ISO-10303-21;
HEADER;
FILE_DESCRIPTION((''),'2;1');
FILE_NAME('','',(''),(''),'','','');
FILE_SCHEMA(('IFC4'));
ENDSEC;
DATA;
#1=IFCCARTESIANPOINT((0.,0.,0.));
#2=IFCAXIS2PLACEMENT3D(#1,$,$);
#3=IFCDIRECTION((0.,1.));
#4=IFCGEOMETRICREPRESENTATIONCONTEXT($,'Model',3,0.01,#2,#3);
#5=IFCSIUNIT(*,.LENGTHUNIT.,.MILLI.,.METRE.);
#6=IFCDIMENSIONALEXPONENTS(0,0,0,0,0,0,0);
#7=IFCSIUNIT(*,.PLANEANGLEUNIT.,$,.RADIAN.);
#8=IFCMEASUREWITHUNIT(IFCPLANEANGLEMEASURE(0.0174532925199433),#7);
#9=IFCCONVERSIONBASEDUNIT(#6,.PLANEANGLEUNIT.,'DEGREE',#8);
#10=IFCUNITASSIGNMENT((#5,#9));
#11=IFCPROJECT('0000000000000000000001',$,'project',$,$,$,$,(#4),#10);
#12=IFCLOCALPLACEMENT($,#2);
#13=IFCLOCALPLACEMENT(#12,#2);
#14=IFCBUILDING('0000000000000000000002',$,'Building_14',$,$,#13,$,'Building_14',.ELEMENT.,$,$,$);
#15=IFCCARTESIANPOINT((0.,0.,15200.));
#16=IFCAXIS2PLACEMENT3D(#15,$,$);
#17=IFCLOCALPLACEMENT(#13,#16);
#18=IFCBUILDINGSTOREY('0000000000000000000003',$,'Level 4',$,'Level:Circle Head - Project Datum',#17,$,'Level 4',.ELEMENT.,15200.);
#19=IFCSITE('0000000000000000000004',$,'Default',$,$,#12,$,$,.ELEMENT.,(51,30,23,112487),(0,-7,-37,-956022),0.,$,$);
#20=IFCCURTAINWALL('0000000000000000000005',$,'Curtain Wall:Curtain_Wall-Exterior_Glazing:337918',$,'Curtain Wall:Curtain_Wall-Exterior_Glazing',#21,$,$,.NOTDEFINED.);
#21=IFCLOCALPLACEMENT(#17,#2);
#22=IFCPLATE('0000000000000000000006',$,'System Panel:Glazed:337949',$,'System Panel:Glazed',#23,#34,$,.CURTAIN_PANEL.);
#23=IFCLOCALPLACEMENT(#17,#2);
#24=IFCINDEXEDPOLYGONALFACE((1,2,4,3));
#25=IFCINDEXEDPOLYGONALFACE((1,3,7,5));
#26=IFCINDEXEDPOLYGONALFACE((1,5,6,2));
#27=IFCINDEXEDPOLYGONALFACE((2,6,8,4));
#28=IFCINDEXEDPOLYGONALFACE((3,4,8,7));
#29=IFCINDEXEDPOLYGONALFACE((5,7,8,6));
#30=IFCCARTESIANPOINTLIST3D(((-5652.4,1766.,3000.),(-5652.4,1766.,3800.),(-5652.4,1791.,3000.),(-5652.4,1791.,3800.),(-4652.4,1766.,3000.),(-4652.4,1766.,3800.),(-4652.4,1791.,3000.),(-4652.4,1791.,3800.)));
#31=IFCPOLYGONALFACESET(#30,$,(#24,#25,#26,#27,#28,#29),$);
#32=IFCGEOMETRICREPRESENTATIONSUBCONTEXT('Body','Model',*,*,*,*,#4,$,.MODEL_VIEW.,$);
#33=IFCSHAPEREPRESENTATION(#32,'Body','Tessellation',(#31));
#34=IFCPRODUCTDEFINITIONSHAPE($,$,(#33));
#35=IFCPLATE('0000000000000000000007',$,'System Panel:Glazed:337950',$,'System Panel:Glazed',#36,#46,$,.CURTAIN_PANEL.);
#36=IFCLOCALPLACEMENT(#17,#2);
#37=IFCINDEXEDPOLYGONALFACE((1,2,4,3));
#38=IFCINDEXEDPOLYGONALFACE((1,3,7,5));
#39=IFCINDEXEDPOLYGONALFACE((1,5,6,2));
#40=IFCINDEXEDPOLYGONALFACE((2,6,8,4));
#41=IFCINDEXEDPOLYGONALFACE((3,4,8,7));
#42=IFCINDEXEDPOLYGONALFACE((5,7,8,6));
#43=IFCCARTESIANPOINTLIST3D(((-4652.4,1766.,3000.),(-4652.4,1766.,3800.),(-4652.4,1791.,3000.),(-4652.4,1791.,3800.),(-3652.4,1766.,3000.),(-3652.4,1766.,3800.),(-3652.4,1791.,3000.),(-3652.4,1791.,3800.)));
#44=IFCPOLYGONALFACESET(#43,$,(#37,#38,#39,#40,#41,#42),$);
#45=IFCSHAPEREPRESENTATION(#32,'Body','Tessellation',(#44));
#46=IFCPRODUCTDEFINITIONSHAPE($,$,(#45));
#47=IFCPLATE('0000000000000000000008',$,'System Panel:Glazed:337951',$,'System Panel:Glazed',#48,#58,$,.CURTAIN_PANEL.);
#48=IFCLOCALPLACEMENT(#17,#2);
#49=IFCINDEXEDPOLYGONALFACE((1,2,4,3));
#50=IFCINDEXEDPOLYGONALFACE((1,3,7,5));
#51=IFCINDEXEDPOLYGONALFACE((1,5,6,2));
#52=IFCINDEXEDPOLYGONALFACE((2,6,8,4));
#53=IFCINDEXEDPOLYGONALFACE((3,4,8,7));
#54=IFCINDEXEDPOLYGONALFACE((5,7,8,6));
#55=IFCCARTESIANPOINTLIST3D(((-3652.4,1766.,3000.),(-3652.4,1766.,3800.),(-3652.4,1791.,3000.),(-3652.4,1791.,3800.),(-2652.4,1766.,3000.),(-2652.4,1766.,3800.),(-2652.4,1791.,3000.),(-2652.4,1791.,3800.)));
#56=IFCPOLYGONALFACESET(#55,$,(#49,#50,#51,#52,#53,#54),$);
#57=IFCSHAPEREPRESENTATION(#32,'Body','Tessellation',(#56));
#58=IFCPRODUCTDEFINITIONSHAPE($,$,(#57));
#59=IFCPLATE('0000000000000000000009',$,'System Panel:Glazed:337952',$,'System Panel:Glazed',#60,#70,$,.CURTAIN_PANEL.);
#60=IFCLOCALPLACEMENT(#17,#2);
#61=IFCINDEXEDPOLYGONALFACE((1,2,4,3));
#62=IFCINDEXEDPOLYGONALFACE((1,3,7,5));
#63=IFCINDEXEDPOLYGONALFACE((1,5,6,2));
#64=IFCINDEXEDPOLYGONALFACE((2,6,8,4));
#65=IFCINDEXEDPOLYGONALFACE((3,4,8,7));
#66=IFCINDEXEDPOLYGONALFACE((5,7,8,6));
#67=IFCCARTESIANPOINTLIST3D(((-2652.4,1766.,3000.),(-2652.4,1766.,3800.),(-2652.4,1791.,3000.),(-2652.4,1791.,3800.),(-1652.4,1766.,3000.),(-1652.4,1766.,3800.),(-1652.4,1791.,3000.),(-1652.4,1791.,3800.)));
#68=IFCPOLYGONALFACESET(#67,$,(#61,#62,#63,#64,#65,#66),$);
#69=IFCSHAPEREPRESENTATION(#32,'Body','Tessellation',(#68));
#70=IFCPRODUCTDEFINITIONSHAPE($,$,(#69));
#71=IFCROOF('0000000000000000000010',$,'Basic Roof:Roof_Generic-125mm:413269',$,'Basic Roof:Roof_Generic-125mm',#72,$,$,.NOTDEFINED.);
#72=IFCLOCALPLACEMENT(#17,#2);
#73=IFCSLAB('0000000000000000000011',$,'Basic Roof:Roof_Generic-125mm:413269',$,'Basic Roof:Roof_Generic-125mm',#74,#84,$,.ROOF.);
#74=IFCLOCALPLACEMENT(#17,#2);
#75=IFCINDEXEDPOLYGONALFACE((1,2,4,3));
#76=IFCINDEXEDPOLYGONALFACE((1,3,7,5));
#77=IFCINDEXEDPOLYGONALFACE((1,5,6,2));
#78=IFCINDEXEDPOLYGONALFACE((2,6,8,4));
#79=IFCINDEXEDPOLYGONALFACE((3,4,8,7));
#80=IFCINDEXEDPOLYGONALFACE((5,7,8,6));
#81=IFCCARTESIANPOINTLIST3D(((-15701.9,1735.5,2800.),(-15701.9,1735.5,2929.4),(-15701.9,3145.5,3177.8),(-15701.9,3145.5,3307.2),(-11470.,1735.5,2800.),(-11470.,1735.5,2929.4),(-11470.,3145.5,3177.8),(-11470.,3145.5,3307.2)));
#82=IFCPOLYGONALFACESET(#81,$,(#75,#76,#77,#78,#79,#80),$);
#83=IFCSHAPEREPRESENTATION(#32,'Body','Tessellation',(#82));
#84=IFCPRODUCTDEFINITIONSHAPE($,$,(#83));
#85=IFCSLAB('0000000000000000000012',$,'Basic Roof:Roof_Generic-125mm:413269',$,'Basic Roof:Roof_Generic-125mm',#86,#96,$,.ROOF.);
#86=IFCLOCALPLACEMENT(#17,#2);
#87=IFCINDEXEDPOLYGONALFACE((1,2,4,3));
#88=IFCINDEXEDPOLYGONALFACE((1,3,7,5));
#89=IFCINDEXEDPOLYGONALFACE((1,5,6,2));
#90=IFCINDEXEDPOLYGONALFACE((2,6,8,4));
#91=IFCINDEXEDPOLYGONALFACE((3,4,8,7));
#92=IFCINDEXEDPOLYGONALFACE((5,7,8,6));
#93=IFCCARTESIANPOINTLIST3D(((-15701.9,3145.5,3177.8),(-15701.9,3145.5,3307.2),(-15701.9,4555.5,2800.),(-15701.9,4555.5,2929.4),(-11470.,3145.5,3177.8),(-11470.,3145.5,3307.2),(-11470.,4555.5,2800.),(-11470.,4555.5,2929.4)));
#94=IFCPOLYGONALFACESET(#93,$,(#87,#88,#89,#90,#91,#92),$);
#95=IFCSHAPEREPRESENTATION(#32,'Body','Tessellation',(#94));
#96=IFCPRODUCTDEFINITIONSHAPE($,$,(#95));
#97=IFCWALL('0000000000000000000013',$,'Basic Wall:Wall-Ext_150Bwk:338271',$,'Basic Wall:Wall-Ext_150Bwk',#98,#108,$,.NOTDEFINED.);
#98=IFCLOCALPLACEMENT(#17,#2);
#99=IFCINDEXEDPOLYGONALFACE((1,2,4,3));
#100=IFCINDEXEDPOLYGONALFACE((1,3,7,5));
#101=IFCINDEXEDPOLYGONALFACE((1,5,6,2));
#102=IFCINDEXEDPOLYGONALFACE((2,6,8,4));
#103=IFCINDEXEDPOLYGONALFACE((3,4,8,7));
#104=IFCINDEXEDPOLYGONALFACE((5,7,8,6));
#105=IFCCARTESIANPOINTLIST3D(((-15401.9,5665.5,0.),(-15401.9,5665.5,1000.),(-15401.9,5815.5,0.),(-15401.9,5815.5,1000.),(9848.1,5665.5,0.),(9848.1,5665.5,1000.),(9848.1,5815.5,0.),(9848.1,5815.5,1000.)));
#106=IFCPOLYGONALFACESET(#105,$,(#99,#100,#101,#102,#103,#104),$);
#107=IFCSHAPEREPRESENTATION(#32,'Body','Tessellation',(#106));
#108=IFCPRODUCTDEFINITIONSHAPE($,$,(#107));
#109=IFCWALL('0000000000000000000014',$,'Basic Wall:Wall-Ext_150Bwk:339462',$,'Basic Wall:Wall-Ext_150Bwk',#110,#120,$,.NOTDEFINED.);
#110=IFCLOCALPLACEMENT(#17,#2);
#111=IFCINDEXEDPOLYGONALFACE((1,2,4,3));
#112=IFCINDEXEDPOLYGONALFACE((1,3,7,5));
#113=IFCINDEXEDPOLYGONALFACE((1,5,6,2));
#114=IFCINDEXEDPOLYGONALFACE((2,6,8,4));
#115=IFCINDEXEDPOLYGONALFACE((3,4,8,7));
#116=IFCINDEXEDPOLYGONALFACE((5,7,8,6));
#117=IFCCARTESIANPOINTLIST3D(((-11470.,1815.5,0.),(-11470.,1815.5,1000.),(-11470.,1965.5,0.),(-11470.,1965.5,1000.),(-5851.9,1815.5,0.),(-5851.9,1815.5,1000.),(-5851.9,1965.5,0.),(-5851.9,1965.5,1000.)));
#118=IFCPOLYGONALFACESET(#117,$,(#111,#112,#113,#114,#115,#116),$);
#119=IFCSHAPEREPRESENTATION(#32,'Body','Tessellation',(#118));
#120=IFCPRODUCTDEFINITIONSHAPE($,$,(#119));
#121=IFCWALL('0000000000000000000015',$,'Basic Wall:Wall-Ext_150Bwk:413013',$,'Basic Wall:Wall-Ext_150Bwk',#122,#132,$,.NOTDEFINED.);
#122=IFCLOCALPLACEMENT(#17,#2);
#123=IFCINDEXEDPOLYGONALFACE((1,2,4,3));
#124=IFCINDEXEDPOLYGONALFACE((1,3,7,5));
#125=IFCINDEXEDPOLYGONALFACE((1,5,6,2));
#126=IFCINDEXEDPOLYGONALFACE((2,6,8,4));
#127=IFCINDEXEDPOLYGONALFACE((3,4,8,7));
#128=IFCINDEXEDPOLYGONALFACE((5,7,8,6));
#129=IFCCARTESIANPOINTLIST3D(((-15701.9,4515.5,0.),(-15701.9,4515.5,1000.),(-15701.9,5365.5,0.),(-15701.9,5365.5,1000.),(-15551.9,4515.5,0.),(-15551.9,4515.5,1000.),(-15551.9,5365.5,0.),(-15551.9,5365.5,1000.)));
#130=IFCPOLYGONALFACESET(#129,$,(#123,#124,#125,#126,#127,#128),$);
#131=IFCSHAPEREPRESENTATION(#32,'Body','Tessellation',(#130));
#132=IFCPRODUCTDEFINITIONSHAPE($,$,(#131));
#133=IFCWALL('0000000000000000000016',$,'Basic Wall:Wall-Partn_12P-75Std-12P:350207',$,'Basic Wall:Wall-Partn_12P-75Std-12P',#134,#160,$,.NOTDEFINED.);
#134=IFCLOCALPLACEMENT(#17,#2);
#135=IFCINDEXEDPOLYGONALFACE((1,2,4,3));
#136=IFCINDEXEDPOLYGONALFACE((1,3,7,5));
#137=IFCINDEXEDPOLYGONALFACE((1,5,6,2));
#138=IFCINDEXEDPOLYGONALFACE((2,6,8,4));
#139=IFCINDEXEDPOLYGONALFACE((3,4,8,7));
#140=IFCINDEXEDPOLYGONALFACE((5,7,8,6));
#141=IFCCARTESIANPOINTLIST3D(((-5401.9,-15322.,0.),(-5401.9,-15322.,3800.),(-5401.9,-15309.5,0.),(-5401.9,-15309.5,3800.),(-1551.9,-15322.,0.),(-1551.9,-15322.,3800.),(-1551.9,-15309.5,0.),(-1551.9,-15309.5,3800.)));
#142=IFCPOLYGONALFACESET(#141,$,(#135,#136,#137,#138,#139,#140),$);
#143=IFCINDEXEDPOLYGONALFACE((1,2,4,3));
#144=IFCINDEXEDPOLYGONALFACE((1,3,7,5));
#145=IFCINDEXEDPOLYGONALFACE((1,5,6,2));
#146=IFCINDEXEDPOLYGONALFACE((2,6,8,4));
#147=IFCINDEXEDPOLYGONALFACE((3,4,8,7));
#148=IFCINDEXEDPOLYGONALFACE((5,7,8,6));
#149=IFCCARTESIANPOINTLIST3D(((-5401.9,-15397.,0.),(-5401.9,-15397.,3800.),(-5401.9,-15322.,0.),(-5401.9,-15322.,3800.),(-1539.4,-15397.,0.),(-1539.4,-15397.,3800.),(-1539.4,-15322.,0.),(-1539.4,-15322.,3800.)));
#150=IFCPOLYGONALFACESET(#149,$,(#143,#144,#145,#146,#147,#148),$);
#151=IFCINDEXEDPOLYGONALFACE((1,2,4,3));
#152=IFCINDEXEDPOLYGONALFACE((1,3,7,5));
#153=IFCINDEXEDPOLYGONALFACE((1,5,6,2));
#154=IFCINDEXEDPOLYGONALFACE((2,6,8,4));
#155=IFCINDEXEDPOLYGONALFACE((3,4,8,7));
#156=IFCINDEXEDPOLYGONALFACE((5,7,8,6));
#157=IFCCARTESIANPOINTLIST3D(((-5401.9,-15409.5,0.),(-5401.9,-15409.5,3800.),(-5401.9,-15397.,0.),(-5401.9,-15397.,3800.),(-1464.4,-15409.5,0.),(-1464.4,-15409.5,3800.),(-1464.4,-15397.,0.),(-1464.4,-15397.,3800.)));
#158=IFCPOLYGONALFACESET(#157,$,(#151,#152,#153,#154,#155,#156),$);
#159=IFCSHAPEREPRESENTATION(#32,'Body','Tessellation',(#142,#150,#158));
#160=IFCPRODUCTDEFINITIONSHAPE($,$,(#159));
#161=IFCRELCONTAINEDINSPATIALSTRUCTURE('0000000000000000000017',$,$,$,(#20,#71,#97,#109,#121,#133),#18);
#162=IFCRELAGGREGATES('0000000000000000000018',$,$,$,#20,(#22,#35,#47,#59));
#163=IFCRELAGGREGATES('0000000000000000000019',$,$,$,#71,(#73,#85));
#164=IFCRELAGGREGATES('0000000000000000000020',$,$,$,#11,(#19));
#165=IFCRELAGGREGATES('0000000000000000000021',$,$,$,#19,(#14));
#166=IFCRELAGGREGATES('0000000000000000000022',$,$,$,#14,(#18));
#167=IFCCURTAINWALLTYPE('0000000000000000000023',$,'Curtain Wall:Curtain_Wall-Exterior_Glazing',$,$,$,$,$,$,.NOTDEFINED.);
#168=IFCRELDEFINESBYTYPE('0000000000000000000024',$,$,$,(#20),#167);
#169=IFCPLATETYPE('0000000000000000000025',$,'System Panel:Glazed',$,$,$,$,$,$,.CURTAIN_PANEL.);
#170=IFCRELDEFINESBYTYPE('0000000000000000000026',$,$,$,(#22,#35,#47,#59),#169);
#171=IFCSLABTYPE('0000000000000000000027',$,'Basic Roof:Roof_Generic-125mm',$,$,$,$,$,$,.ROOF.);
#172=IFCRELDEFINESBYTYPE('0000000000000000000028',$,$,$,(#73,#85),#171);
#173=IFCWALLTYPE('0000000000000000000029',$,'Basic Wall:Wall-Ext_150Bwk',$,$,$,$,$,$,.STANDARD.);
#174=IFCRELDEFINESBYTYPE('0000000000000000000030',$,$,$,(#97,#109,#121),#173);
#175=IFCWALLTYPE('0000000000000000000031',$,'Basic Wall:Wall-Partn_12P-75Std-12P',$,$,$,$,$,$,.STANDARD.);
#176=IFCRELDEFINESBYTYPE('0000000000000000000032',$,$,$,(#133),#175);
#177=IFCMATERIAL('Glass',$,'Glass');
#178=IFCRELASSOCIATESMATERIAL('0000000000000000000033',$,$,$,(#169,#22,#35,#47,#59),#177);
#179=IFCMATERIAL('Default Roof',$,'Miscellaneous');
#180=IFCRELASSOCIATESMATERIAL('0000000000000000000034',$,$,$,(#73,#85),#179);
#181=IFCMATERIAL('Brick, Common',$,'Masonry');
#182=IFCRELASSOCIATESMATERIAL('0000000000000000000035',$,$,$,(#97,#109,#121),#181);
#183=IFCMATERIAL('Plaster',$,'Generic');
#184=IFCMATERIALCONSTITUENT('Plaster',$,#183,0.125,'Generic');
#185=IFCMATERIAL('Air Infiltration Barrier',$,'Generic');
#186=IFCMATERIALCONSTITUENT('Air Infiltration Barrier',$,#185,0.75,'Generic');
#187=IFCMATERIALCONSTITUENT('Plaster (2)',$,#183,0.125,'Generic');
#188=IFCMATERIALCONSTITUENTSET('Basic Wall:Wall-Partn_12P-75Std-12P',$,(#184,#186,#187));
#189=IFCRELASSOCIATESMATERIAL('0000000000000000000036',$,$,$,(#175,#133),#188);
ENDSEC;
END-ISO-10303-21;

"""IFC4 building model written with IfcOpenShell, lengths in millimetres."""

from ifc_helpers import new_model, entity, si_unit, converted_unit, direction, frame, origin, place, context, subcontext, project, spatial, indexed_curve, outline, extrude, source, transform, mapped, material, constituent, constituent_set, type_object, type_shapes, element, aggregate, save


model = new_model("IFC4")

# Units and contexts
model_context = context("Model", 3, precision=0.01, world=origin(), true_north=direction((0.0, 1.0)))
body_context = subcontext(model_context, "Body", "Model", "MODEL_VIEW")
ifc_project = project(units=[si_unit("LENGTHUNIT", "METRE", prefix="MILLI"), converted_unit("PLANEANGLEUNIT", "DEGREE", entity("IfcPlaneAngleMeasure", 0.0174532925199433), si_unit("PLANEANGLEUNIT", "RADIAN"), dimensions=[0, 0, 0, 0, 0, 0, 0])], contexts=[model_context])

# Site, building, storey
site_placement = place(None, origin())
site = spatial("IfcSite", under=ifc_project, at=site_placement, Name="Default", CompositionType="ELEMENT", RefLatitude=(51, 30, 23, 112487), RefLongitude=(0, -7, -37, -956022), RefElevation=0.0)
building_placement = place(site_placement, origin())
building = spatial("IfcBuilding", under=site, at=building_placement, Name="Building_14", LongName="Building_14", CompositionType="ELEMENT")
storey_placement = place(building_placement, frame((0.0, 0.0, 15200.0)))
storey = spatial("IfcBuildingStorey", under=building, at=storey_placement, Name="Level 4", ObjectType="Level:Circle Head - Project Datum", LongName="Level 4", CompositionType="ELEMENT", Elevation=15200.0)

# Curtain wall, plates
curtain_wall_type = type_object("IfcCurtainWallType", Name="Curtain Wall:Curtain_Wall-Exterior_Glazing", PredefinedType="NOTDEFINED")
curtain_wall_placement = place(storey_placement, frame((0.0, 0.0, -15200.0)))
curtain_wall = element("IfcCurtainWall", 1, at=curtain_wall_placement, inside=storey, type_object=curtain_wall_type, Name="Curtain Wall:Curtain_Wall-Exterior_Glazing:337918", ObjectType="Curtain Wall:Curtain_Wall-Exterior_Glazing", PredefinedType="NOTDEFINED")
ifc_material_1 = material(Name="Glass", Category="Glass")
plate_type_1 = type_object("IfcPlateType", Name="System Panel:Glazed", PredefinedType="CURTAIN_PANEL", material=ifc_material_1)
shared_shape_1 = source(origin(), body_context, "Body", "SweptSolid", [
    extrude(outline(indexed_curve([(-12.5, -500.0), (12.5, -500.0), (12.5, 500.0), (-12.5, 500.0), (-12.5, -500.0)], self_intersect=False)), frame((0.0, -37.0, 0.0), z_axis=(0.0, 0.0, 1.0), x_axis=(0.0, 1.0, 0.0)), (0.0, 0.0, 1.0), 800.0),
])
type_shapes(plate_type_1, [shared_shape_1])
plate_1_placement = place(curtain_wall_placement, frame((-5152.4, 1815.5, 18200.0)))
plate_1 = element("IfcPlate", 2, at=plate_1_placement, type_object=plate_type_1, material=ifc_material_1, Name="System Panel:Glazed:337949", ObjectType="System Panel:Glazed", PredefinedType="CURTAIN_PANEL", context=body_context, shape_type="MappedRepresentation", body=[
    mapped(shared_shape_1, transform((0.0, 0.0, 0.0), scale=1.0)),
])
plate_2_placement = place(curtain_wall_placement, frame((-4152.4, 1815.5, 18200.0)))
plate_2 = element("IfcPlate", 3, at=plate_2_placement, type_object=plate_type_1, material=ifc_material_1, Name="System Panel:Glazed:337950", ObjectType="System Panel:Glazed", PredefinedType="CURTAIN_PANEL", context=body_context, shape_type="MappedRepresentation", body=[
    mapped(shared_shape_1, transform((0.0, 0.0, 0.0), scale=1.0)),
])
plate_3_placement = place(curtain_wall_placement, frame((-3152.4, 1815.5, 18200.0)))
plate_3 = element("IfcPlate", 4, at=plate_3_placement, type_object=plate_type_1, material=ifc_material_1, Name="System Panel:Glazed:337951", ObjectType="System Panel:Glazed", PredefinedType="CURTAIN_PANEL", context=body_context, shape_type="MappedRepresentation", body=[
    mapped(shared_shape_1, transform((0.0, 0.0, 0.0), scale=1.0)),
])
plate_4_placement = place(curtain_wall_placement, frame((-2152.4, 1815.5, 18200.0)))
plate_4 = element("IfcPlate", 5, at=plate_4_placement, type_object=plate_type_1, material=ifc_material_1, Name="System Panel:Glazed:337952", ObjectType="System Panel:Glazed", PredefinedType="CURTAIN_PANEL", context=body_context, shape_type="MappedRepresentation", body=[
    mapped(shared_shape_1, transform((0.0, 0.0, 0.0), scale=1.0)),
])
aggregate(curtain_wall, [plate_1, plate_2, plate_3, plate_4])

# Roof, slabs
roof_placement = place(storey_placement, frame((-15701.9, 1735.5, 2800.0)))
roof = element("IfcRoof", 6, at=roof_placement, inside=storey, Name="Basic Roof:Roof_Generic-125mm:413269", ObjectType="Basic Roof:Roof_Generic-125mm", PredefinedType="NOTDEFINED")
ifc_material_2 = material(Name="Default Roof", Category="Miscellaneous")
slab_type = type_object("IfcSlabType", Name="Basic Roof:Roof_Generic-125mm", PredefinedType="ROOF")
slab_1_placement = place(roof_placement, origin())
slab_1 = element("IfcSlab", 7, at=slab_1_placement, type_object=slab_type, material=ifc_material_2, Name="Basic Roof:Roof_Generic-125mm:413269", ObjectType="Basic Roof:Roof_Generic-125mm", PredefinedType="ROOF", context=body_context, shape_type="SweptSolid", body=[
    extrude(outline(indexed_curve([(2116.0, -729.9), (2116.0, 729.9), (-2116.0, 729.9), (-2116.0, -729.9), (2116.0, -729.9)], self_intersect=False)), frame((2116.0, 705.0, 188.9), z_axis=(0.0, -0.258819, 0.965926), x_axis=(1.0, 0.0, 0.0)), (0.0, 0.258819, 0.965926), 129.4),
])
slab_2_placement = place(roof_placement, origin())
slab_2 = element("IfcSlab", 8, at=slab_2_placement, type_object=slab_type, material=ifc_material_2, Name="Basic Roof:Roof_Generic-125mm:413269", ObjectType="Basic Roof:Roof_Generic-125mm", PredefinedType="ROOF", context=body_context, shape_type="SweptSolid", body=[
    extrude(outline(indexed_curve([(-2116.0, -729.9), (2116.0, -729.9), (2116.0, 729.9), (-2116.0, 729.9), (-2116.0, -729.9)], self_intersect=False)), frame((2116.0, 2115.0, 188.9), z_axis=(0.0, 0.258819, 0.965926), x_axis=(1.0, 0.0, 0.0)), (0.0, -0.258819, 0.965926), 129.4),
])
aggregate(roof, [slab_1, slab_2])

# Walls
ifc_material_3 = material(Name="Brick, Common", Category="Masonry")
wall_type_1 = type_object("IfcWallType", Name="Basic Wall:Wall-Ext_150Bwk", PredefinedType="STANDARD")
wall_1_placement = place(storey_placement, frame((-15401.9, 5740.5, 0.0)))
element("IfcWall", 9, at=wall_1_placement, inside=storey, type_object=wall_type_1, material=ifc_material_3, Name="Basic Wall:Wall-Ext_150Bwk:338271", ObjectType="Basic Wall:Wall-Ext_150Bwk", PredefinedType="NOTDEFINED", context=body_context, shape_type="SweptSolid", body=[
    extrude(outline(indexed_curve([(25250.0, 75.0), (0.0, 75.0), (0.0, -75.0), (25250.0, -75.0), (25250.0, 75.0)], self_intersect=False)), origin(), (0.0, 0.0, 1.0), 1000.0),
])
wall_2_placement = place(storey_placement, frame((-5851.9, 1890.5, 0.0), z_axis=(0.0, 0.0, 1.0), x_axis=(-1.0, 0.0, 0.0)))
element("IfcWall", 10, at=wall_2_placement, inside=storey, type_object=wall_type_1, material=ifc_material_3, Name="Basic Wall:Wall-Ext_150Bwk:339462", ObjectType="Basic Wall:Wall-Ext_150Bwk", PredefinedType="NOTDEFINED", context=body_context, shape_type="SweptSolid", body=[
    extrude(outline(indexed_curve([(5618.1, 75.0), (0.0, 75.0), (0.0, -75.0), (5618.1, -75.0), (5618.1, 75.0)], self_intersect=False)), origin(), (0.0, 0.0, 1.0), 1000.0),
])
wall_3_placement = place(storey_placement, frame((-15626.9, 4515.5, 0.0), z_axis=(0.0, 0.0, 1.0), x_axis=(0.0, 1.0, 0.0)))
element("IfcWall", 11, at=wall_3_placement, inside=storey, type_object=wall_type_1, material=ifc_material_3, Name="Basic Wall:Wall-Ext_150Bwk:413013", ObjectType="Basic Wall:Wall-Ext_150Bwk", PredefinedType="NOTDEFINED", context=body_context, shape_type="SweptSolid", body=[
    extrude(outline(indexed_curve([(850.0, 75.0), (0.0, 75.0), (0.0, -75.0), (850.0, -75.0), (850.0, 75.0)], self_intersect=False)), origin(), (0.0, 0.0, 1.0), 1000.0),
])
ifc_material_4 = material(Name="Plaster", Category="Generic")
ifc_constituent_1 = constituent(ifc_material_4, Name="Plaster", Category="Generic", fraction=0.125)
ifc_material_5 = material(Name="Air Infiltration Barrier", Category="Generic")
ifc_constituent_2 = constituent(ifc_material_5, Name="Air Infiltration Barrier", Category="Generic", fraction=0.75)
ifc_constituent_3 = constituent(ifc_material_4, Name="Plaster (2)", Category="Generic", fraction=0.125)
ifc_constituent_set_1 = constituent_set(constituents=[ifc_constituent_1, ifc_constituent_2, ifc_constituent_3], Name="Basic Wall:Wall-Partn_12P-75Std-12P")
wall_type_2 = type_object("IfcWallType", Name="Basic Wall:Wall-Partn_12P-75Std-12P", PredefinedType="STANDARD", material=ifc_constituent_set_1)

# Wall
wall_4_placement = place(storey_placement, frame((-5401.9, -15359.5, 0.0)))
element("IfcWall", 12, at=wall_4_placement, inside=storey, type_object=wall_type_2, material=ifc_constituent_set_1, Name="Basic Wall:Wall-Partn_12P-75Std-12P:350207", ObjectType="Basic Wall:Wall-Partn_12P-75Std-12P", PredefinedType="NOTDEFINED", context=body_context, shape_type="SweptSolid", body=[
    extrude(outline(indexed_curve([(-6.3, -1925.0), (6.2, -1925.0), (6.3, 1925.0), (-6.2, 1925.0), (-6.3, -1925.0)], self_intersect=False)), frame((1925.0, 43.8, 0.0), z_axis=(0.0, 0.0, 1.0), x_axis=(0.0, -1.0, 0.0)), (0.0, 0.0, 1.0), 3800.0),
    extrude(outline(indexed_curve([(-1931.2, -37.5), (1931.2, -37.5), (1931.2, 37.5), (-1931.2, 37.5), (-1931.2, -37.5)], self_intersect=False)), frame((1931.2, 0.0, 0.0)), (0.0, 0.0, 1.0), 3800.0),
    extrude(outline(indexed_curve([(-6.2, -1968.8), (6.3, -1968.8), (6.2, 1968.8), (-6.3, 1968.8), (-6.2, -1968.8)], self_intersect=False)), frame((1968.8, -43.8, 0.0), z_axis=(0.0, 0.0, 1.0), x_axis=(0.0, 1.0, 0.0)), (0.0, 0.0, 1.0), 3800.0),
])

save(model, "model.ifc")
